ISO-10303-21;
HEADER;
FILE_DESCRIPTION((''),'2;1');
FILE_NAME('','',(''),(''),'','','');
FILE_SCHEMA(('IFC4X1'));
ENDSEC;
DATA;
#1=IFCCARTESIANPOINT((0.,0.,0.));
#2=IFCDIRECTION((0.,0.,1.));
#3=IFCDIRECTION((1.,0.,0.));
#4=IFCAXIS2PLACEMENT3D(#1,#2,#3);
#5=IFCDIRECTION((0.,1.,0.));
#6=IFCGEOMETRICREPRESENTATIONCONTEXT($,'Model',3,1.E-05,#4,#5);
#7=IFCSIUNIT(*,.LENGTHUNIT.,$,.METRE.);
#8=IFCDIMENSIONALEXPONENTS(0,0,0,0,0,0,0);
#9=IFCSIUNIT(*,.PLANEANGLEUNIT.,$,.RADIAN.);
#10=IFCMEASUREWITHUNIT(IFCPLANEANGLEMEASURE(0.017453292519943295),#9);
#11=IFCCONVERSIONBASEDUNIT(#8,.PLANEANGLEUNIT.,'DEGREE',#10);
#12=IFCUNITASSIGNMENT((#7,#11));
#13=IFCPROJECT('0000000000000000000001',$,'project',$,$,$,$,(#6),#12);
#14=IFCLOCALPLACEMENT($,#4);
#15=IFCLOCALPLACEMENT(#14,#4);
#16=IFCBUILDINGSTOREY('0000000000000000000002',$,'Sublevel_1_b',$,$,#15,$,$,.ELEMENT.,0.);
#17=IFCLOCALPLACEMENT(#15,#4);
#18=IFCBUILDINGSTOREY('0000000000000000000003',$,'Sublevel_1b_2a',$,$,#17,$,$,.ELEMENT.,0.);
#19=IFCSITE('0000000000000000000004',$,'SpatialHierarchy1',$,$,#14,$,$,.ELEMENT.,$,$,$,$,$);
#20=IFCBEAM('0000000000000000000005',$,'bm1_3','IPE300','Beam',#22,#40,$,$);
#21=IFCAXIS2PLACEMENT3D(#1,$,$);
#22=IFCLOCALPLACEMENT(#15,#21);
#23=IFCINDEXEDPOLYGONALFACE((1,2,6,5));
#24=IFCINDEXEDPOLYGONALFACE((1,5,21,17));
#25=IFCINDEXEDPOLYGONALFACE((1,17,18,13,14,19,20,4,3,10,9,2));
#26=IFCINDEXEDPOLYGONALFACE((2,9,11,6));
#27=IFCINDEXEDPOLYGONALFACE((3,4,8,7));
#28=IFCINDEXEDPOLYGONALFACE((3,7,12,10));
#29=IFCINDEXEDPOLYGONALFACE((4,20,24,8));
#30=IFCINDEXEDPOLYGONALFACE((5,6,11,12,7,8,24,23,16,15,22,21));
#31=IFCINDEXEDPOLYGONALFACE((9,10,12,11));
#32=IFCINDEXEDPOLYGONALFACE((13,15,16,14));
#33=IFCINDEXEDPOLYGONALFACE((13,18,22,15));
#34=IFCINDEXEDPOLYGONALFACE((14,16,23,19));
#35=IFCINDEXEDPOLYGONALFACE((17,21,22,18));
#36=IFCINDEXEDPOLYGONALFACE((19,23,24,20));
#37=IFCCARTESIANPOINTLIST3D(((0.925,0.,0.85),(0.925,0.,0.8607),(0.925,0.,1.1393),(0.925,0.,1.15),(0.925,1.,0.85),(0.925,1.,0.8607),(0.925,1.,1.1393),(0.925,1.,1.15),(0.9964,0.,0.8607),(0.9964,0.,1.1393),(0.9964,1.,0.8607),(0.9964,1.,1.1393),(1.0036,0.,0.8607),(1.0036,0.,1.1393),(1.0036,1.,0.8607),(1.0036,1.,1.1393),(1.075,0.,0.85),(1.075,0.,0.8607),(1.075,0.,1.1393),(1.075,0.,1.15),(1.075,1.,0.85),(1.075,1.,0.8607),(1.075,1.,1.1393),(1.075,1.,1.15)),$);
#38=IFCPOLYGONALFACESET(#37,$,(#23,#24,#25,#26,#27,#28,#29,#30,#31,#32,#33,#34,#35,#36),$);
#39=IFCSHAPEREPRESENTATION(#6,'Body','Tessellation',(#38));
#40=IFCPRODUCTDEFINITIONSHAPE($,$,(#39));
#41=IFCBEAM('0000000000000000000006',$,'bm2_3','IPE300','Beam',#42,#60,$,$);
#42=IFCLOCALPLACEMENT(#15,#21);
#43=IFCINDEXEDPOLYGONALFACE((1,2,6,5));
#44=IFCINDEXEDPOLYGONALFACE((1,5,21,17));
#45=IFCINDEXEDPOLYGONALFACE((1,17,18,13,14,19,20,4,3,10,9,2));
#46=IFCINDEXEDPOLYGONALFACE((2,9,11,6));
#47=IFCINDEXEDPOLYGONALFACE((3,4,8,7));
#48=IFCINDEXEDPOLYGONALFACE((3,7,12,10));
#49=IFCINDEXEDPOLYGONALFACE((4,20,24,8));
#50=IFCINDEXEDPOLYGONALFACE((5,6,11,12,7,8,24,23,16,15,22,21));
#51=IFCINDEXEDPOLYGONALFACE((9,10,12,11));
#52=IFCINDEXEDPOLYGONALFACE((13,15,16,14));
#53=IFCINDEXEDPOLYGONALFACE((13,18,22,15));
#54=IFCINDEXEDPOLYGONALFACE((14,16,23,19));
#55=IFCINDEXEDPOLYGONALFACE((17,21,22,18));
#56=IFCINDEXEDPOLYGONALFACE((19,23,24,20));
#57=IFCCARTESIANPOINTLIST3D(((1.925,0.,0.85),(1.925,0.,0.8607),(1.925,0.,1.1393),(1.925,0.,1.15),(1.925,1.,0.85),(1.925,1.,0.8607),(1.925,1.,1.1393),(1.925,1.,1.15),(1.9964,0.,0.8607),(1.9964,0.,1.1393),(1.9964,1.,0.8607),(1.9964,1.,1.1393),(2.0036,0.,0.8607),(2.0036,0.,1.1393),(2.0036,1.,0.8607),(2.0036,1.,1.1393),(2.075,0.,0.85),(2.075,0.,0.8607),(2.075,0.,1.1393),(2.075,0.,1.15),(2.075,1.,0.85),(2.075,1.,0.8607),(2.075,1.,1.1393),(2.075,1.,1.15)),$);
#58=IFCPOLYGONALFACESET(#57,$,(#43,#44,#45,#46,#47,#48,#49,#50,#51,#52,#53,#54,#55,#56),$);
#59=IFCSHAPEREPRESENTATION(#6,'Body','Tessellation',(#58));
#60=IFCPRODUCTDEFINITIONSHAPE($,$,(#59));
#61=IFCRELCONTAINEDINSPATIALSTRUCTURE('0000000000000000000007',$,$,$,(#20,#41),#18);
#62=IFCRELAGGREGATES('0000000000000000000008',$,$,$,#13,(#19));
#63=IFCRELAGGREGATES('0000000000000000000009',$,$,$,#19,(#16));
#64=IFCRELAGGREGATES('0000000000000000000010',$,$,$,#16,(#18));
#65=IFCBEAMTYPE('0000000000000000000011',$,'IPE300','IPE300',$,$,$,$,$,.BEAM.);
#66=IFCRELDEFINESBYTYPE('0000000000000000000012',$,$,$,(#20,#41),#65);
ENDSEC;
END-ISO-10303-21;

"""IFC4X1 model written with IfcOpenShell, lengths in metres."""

from ifc_helpers import new_model, entity, si_unit, converted_unit, direction, frame, origin, origin_with_axes, place, context, project, spatial, i_section, extrude, type_object, element, save


model = new_model("IFC4X1")

# Units and contexts
model_context = context("Model", 3, precision=1e-05, world=origin_with_axes(), true_north=direction((0.0, 1.0, 0.0)))
ifc_project = project(units=[si_unit("LENGTHUNIT", "METRE"), converted_unit("PLANEANGLEUNIT", "DEGREE", entity("IfcPlaneAngleMeasure", 0.017453292519943295), si_unit("PLANEANGLEUNIT", "RADIAN"), dimensions=[0, 0, 0, 0, 0, 0, 0])], contexts=[model_context])

# Site, storeys
site_placement = place(None, origin_with_axes())
site = spatial("IfcSite", under=ifc_project, at=site_placement, Name="SpatialHierarchy1", CompositionType="ELEMENT")
storey_1_placement = place(site_placement, origin_with_axes())
storey_1 = spatial("IfcBuildingStorey", under=site, at=storey_1_placement, Name="Sublevel_1_b", CompositionType="ELEMENT", Elevation=0.0)
storey_2_placement = place(storey_1_placement, origin_with_axes())
storey_2 = spatial("IfcBuildingStorey", under=storey_1, at=storey_2_placement, Name="Sublevel_1b_2a", CompositionType="ELEMENT", Elevation=0.0)

# Beams
beam_type = type_object("IfcBeamType", Name="IPE300", Description="IPE300", PredefinedType="BEAM")
placement_1 = place(storey_2_placement, origin_with_axes())
beam_1_placement = place(placement_1, frame((1.0, 0.0, 1.0), z_axis=(0.0, 1.0, 0.0), x_axis=(-1.0, 0.0, 0.0)))
element("IfcBeam", 1, at=beam_1_placement, inside=storey_2, type_object=beam_type, Name="bm1_3", Description="IPE300", ObjectType="Beam", context=model_context, shape_type="SweptSolid", body=[
    extrude(i_section(OverallWidth=0.15, OverallDepth=0.3, WebThickness=0.0071, FlangeThickness=0.0107), origin(), (0.0, 0.0, 1.0), 1.0),
])
placement_2 = place(storey_2_placement, origin_with_axes())
beam_2_placement = place(placement_2, frame((2.0, 0.0, 1.0), z_axis=(0.0, 1.0, 0.0), x_axis=(-1.0, 0.0, 0.0)))
element("IfcBeam", 2, at=beam_2_placement, inside=storey_2, type_object=beam_type, Name="bm2_3", Description="IPE300", ObjectType="Beam", context=model_context, shape_type="SweptSolid", body=[
    extrude(i_section(OverallWidth=0.15, OverallDepth=0.3, WebThickness=0.0071, FlangeThickness=0.0107), origin(), (0.0, 0.0, 1.0), 1.0),
])

save(model, "model.ifc")
